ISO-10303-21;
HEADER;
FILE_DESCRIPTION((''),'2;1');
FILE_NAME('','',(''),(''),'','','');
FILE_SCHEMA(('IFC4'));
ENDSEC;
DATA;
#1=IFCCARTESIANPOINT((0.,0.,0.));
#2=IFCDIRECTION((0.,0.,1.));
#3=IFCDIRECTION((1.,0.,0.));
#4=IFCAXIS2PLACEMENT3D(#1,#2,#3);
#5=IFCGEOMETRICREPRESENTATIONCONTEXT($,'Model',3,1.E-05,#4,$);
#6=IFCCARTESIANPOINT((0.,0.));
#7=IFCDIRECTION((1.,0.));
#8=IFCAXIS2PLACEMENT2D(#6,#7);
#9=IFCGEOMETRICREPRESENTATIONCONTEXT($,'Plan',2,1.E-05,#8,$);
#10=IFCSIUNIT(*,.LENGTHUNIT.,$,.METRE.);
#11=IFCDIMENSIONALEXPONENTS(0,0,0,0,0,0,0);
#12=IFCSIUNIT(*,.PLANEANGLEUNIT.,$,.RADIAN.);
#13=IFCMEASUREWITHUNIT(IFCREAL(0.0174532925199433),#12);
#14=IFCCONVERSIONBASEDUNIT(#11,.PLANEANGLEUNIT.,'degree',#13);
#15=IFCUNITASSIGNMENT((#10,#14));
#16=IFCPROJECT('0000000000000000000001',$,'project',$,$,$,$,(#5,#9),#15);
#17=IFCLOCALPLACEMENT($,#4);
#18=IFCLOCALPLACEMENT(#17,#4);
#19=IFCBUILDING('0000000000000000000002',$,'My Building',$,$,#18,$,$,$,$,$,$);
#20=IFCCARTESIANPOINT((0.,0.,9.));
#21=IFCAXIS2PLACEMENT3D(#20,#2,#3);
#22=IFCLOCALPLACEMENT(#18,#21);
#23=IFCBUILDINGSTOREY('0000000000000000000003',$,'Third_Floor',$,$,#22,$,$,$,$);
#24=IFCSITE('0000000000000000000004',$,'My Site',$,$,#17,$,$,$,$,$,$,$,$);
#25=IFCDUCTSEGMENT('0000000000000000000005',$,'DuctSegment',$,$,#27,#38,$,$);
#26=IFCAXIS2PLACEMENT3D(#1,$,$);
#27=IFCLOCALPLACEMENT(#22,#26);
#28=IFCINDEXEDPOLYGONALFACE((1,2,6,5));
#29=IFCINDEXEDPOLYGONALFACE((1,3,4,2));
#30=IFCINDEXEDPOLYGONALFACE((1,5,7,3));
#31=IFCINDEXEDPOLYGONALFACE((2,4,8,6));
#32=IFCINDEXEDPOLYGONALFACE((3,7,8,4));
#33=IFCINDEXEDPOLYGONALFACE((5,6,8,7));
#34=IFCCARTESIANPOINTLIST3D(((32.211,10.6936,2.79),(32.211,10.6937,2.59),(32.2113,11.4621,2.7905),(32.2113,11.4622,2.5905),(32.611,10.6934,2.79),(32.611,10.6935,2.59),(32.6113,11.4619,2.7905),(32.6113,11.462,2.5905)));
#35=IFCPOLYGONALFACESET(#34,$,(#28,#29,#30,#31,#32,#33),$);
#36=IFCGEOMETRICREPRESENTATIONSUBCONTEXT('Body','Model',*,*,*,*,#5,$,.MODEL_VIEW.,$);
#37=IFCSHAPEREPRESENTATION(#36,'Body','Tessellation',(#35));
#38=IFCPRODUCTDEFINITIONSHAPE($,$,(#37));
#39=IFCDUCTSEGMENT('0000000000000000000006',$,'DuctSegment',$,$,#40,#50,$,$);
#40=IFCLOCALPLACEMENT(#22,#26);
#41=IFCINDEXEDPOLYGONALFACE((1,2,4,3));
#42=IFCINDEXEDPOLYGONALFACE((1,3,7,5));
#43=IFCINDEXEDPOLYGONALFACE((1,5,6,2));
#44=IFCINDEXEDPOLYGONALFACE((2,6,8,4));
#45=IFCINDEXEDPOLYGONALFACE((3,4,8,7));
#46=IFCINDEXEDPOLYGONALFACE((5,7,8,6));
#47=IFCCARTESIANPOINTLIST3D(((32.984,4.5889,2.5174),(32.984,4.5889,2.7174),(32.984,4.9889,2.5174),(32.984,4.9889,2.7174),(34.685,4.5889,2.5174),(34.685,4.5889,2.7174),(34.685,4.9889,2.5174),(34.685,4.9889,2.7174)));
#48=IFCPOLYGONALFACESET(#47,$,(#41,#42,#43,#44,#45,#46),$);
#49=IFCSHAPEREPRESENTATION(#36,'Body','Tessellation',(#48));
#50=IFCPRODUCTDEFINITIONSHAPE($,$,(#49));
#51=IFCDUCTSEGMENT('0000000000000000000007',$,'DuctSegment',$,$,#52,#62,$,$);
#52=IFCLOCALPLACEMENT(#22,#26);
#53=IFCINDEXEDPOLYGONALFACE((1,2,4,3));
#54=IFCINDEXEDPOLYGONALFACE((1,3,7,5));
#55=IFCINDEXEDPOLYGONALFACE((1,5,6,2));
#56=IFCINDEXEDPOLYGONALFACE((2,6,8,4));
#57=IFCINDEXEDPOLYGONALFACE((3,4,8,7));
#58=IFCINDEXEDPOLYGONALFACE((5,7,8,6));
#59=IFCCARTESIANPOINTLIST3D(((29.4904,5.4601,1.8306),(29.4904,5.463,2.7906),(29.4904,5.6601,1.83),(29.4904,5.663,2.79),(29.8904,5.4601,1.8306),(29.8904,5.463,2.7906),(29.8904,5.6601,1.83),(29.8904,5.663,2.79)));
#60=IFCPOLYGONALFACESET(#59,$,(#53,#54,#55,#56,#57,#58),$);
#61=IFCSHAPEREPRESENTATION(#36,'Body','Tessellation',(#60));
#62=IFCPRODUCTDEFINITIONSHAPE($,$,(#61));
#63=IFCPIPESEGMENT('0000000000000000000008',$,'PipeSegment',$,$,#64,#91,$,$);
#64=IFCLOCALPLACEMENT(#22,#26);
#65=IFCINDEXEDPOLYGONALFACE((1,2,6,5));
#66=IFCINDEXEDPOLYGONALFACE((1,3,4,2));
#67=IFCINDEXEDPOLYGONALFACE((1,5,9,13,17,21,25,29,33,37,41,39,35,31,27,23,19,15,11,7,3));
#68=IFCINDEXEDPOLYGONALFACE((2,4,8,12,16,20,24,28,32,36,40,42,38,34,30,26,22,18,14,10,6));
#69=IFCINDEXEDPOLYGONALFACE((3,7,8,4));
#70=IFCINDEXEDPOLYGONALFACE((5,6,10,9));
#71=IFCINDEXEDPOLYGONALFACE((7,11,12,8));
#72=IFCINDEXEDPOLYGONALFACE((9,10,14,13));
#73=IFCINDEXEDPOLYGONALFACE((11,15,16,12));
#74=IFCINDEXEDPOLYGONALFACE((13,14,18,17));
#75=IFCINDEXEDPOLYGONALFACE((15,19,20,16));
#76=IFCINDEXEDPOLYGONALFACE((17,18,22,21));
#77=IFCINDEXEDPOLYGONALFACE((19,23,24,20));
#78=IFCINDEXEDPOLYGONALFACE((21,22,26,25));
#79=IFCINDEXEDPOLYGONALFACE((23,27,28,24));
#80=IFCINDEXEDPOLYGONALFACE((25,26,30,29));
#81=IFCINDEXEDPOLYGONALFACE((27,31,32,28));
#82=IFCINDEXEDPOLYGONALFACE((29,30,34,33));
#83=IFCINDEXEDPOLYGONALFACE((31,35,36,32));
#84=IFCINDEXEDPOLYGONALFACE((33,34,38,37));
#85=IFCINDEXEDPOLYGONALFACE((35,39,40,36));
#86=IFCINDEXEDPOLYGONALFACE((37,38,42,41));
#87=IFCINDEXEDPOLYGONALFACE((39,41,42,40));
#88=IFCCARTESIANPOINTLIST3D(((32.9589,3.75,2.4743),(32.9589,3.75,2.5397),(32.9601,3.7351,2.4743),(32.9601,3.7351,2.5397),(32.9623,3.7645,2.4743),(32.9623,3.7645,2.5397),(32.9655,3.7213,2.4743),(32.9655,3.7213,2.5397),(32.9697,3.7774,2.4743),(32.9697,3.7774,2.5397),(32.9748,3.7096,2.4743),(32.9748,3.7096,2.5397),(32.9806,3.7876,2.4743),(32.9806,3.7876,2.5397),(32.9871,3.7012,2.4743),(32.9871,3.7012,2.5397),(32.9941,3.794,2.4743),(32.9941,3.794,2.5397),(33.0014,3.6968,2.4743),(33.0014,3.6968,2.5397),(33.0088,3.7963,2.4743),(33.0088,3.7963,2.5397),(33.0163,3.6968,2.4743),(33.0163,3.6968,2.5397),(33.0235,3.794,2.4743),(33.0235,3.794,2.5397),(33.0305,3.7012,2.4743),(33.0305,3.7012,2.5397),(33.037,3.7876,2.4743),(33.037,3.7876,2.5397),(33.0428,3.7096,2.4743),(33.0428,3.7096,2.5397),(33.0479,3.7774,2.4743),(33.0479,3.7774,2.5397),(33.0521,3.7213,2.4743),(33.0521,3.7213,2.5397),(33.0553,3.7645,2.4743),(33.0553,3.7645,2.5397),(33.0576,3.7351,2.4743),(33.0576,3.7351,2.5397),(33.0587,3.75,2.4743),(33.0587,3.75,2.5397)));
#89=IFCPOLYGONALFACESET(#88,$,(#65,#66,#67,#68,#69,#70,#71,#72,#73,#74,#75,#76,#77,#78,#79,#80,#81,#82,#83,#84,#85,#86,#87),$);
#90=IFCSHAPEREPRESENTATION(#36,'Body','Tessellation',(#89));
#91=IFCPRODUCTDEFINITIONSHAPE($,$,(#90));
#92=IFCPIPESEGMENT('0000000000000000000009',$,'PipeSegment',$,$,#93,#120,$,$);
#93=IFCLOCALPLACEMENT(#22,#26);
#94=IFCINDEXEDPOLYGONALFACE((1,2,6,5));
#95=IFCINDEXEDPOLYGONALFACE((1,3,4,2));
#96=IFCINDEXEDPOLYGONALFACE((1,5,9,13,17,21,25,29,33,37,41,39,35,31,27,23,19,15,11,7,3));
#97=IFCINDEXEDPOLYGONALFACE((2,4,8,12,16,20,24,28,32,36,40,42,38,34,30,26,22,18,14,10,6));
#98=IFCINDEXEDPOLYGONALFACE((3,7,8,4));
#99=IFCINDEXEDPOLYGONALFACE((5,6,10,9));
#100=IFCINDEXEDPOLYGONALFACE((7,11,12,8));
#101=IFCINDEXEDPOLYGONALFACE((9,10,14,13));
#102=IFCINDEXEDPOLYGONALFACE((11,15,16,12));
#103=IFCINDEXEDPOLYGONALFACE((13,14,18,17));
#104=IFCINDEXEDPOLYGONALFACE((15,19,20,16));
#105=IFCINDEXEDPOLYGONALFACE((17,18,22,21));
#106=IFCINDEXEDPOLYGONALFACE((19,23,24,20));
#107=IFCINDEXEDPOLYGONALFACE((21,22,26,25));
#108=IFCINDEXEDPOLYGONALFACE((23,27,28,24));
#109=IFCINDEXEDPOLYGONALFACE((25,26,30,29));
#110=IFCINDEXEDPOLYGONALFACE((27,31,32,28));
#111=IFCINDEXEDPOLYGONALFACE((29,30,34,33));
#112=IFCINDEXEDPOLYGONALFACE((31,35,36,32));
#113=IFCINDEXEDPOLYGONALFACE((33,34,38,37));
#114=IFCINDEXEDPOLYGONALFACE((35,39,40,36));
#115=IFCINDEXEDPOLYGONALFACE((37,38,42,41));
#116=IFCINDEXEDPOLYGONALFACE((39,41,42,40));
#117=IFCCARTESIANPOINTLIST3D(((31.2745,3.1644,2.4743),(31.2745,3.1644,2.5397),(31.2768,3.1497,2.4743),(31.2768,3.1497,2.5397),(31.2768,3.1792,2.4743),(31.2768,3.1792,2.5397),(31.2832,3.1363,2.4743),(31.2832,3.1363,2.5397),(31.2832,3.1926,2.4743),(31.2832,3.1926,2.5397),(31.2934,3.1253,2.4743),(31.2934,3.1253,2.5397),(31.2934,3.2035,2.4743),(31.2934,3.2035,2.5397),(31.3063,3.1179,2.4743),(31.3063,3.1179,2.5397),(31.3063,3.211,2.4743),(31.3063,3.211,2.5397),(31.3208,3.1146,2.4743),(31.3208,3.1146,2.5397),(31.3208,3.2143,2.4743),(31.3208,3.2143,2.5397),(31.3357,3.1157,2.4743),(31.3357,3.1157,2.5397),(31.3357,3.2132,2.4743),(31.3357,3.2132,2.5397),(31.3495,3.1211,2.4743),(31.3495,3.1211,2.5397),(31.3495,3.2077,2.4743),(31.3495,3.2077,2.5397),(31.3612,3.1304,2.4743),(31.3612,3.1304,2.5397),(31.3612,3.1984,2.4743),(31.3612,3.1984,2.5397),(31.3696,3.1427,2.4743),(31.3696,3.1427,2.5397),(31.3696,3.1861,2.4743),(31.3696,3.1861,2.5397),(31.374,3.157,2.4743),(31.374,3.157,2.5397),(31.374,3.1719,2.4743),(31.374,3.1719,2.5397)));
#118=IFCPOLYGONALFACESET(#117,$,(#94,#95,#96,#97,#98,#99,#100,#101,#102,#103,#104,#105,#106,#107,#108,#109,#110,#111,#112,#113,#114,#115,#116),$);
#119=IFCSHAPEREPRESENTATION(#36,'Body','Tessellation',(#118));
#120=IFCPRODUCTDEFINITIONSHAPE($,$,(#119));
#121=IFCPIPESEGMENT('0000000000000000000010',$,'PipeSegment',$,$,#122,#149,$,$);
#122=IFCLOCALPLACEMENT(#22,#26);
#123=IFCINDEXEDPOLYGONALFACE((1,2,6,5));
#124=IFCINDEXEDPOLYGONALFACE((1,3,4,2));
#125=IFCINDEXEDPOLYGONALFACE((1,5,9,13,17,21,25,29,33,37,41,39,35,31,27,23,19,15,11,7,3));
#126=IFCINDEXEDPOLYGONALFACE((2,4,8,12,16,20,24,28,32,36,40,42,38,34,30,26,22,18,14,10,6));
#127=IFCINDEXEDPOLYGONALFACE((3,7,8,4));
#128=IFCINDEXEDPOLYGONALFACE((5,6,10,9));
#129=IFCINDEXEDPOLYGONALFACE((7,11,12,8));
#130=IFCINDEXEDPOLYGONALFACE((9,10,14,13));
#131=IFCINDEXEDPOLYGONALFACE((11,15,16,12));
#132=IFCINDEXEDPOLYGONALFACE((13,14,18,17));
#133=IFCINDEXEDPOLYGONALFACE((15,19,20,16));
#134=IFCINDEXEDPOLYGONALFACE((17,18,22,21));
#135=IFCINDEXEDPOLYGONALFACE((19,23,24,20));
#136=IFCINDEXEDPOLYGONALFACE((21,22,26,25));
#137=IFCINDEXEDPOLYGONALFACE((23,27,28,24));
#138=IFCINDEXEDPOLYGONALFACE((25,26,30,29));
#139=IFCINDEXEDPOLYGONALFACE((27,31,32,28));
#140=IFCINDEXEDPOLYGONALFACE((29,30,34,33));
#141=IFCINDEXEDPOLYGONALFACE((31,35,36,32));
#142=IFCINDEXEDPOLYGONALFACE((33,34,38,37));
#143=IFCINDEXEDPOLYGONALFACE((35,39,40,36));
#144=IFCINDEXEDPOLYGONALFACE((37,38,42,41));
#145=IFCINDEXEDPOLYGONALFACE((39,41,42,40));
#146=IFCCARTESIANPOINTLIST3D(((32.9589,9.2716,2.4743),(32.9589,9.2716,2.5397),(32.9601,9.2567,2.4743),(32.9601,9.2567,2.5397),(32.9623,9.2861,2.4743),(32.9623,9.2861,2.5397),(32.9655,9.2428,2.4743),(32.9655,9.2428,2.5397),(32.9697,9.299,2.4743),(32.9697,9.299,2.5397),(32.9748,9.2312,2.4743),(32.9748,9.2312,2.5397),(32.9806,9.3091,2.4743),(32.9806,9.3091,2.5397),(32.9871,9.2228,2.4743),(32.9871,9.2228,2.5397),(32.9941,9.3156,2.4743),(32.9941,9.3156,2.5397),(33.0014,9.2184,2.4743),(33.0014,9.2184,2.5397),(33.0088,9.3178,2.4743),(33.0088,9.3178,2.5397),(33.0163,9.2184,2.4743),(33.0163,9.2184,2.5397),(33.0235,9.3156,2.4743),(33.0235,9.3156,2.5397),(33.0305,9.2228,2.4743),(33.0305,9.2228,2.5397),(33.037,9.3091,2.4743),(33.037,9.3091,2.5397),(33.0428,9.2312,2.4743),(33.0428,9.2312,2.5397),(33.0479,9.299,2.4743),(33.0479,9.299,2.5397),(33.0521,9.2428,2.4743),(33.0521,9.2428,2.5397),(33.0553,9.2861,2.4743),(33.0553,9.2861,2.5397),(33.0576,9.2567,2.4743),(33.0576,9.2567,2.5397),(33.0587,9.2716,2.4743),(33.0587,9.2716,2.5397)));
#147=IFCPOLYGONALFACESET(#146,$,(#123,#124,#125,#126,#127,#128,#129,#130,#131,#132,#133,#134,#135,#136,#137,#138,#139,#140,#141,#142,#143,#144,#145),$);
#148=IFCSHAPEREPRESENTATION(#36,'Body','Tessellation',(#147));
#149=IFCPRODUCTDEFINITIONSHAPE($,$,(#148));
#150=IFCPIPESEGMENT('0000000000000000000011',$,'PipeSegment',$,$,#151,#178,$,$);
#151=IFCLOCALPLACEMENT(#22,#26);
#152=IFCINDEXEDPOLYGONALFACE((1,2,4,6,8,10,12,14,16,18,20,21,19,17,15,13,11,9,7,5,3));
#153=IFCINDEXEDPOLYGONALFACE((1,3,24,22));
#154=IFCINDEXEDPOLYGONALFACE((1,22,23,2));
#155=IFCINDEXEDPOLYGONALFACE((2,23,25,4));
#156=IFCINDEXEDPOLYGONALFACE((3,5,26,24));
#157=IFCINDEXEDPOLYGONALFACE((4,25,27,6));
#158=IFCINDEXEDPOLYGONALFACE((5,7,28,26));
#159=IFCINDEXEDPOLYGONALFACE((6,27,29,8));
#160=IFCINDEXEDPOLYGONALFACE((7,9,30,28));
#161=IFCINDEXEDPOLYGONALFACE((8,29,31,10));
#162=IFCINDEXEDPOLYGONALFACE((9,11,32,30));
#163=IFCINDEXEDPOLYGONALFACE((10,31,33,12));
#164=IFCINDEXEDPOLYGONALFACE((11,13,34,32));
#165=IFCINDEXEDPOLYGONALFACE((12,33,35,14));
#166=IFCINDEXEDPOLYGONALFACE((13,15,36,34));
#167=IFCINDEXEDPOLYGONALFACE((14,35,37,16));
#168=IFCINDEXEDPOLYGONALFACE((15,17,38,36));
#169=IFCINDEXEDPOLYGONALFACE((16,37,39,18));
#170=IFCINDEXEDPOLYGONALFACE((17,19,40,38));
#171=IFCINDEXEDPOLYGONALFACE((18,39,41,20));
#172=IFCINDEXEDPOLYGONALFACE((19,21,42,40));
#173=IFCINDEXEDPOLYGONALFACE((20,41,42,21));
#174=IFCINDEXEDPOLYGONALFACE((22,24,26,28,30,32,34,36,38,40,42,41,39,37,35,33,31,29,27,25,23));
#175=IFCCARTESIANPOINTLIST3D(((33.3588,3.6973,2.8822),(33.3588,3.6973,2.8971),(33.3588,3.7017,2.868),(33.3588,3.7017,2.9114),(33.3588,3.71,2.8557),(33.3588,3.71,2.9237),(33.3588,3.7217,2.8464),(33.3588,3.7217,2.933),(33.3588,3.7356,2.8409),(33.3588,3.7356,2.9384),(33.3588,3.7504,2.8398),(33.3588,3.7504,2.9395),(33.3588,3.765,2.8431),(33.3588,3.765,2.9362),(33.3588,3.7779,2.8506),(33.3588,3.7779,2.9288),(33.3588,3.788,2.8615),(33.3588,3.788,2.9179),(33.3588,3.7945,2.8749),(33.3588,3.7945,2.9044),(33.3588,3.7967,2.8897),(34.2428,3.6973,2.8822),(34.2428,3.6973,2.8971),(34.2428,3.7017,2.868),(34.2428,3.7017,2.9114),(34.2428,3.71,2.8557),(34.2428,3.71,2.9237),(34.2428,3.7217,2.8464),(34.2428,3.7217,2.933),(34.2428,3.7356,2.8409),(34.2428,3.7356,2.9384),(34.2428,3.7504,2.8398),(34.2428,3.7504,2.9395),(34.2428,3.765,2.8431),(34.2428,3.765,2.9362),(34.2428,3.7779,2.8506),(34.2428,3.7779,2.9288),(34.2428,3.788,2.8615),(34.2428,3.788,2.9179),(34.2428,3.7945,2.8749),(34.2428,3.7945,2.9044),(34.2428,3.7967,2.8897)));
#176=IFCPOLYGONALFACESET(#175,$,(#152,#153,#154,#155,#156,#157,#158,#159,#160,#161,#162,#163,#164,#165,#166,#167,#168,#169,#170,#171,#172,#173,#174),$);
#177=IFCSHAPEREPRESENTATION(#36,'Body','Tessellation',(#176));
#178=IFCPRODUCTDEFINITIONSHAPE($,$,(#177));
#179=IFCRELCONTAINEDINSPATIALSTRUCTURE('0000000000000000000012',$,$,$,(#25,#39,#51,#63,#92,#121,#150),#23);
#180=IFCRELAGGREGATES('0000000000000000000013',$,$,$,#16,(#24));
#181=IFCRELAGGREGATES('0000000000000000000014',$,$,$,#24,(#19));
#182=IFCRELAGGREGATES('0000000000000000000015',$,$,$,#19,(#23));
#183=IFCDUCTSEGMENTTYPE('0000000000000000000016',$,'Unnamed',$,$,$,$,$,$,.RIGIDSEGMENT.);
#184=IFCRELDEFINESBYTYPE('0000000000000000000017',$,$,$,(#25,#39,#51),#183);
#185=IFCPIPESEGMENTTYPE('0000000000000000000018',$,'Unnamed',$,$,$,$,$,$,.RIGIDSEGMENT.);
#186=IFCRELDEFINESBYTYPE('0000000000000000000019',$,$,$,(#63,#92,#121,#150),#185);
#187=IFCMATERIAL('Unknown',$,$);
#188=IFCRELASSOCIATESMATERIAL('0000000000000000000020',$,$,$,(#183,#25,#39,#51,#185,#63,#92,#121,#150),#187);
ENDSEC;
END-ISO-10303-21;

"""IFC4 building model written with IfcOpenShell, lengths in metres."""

from ifc_helpers import new_model, entity, si_unit, converted_unit, frame, origin_with_axes, origin_2d_with_axis, place, context, subcontext, project, spatial, rectangle, circle, extrude, material, material_profile, profile_set, profile_usage, type_object, element, save


model = new_model("IFC4")

# Units and contexts
model_context = context("Model", 3, precision=1e-05, world=origin_with_axes())
plan_context = context("Plan", 2, precision=1e-05, world=origin_2d_with_axis())
body_context_1 = subcontext(model_context, "Body", "Model", "MODEL_VIEW")
ifc_project = project(units=[si_unit("LENGTHUNIT", "METRE"), converted_unit("PLANEANGLEUNIT", "degree", entity("IfcReal", 0.0174532925199433), si_unit("PLANEANGLEUNIT", "RADIAN"), dimensions=[0, 0, 0, 0, 0, 0, 0])], contexts=[model_context, plan_context])

# Site, building, storey
site_placement = place(None, origin_with_axes())
site = spatial("IfcSite", under=ifc_project, at=site_placement, Name="My Site")
building_placement = place(site_placement, origin_with_axes())
building = spatial("IfcBuilding", under=site, at=building_placement, Name="My Building")
storey_placement = place(building_placement, frame((0.0, 0.0, 9.0), z_axis=(0.0, 0.0, 1.0), x_axis=(1.0, 0.0, 0.0)))
storey = spatial("IfcBuildingStorey", under=building, at=storey_placement, Name="Third_Floor")

# Shared definitions
ifc_material = material(Name="Unknown")

# Duct segments
ifc_material_profile_1 = material_profile(ifc_material, rectangle(XDim=0.4, YDim=0.2))
ifc_profile_set_1 = profile_set([ifc_material_profile_1])
duct_segment_type = type_object("IfcDuctSegmentType", Name="Unnamed", PredefinedType="RIGIDSEGMENT", material=ifc_profile_set_1)
ifc_profile_usage_1 = profile_usage(ifc_profile_set_1, cardinal=5)
duct_segment_1_placement = place(storey_placement, frame((32.4113, 11.462, 2.6905), z_axis=(-0.000397, -1.0, -0.000603), x_axis=(1.0, -0.000397, 0.0)))
element("IfcDuctSegment", 1, at=duct_segment_1_placement, inside=storey, type_object=duct_segment_type, material=ifc_profile_usage_1, Name="DuctSegment", context=body_context_1, shape_type="SweptSolid", body=[
    extrude(rectangle(XDim=0.4, YDim=0.2), origin_with_axes(), (0.0, 0.0, 1.0), 0.7685),
])
ifc_profile_usage_2 = profile_usage(ifc_profile_set_1, cardinal=5)
duct_segment_2_placement = place(storey_placement, frame((34.685, 4.7889, 2.6174), z_axis=(-1.0, 0.000001, 0.000001), x_axis=(-0.000001, -1.0, 0.0)))
element("IfcDuctSegment", 2, at=duct_segment_2_placement, inside=storey, type_object=duct_segment_type, material=ifc_profile_usage_2, Name="DuctSegment", context=body_context_1, shape_type="SweptSolid", body=[
    extrude(rectangle(XDim=0.4, YDim=0.2), origin_with_axes(), (0.0, 0.0, 1.0), 1.701),
])
ifc_profile_usage_3 = profile_usage(ifc_profile_set_1, cardinal=5)
duct_segment_3_placement = place(storey_placement, frame((29.6904, 5.563, 2.7903), z_axis=(0.0, -0.00299, -0.999996), x_axis=(1.0, 0.0, 0.0)))
element("IfcDuctSegment", 3, at=duct_segment_3_placement, inside=storey, type_object=duct_segment_type, material=ifc_profile_usage_3, Name="DuctSegment", context=body_context_1, shape_type="SweptSolid", body=[
    extrude(rectangle(XDim=0.4, YDim=0.2), origin_with_axes(), (0.0, 0.0, 1.0), 0.96),
])

# Pipe segments
ifc_material_profile_2 = material_profile(ifc_material, circle(Radius=0.05))
ifc_profile_set_2 = profile_set([ifc_material_profile_2])
ifc_profile_usage_4 = profile_usage(ifc_profile_set_2, cardinal=5)
pipe_segment_type = type_object("IfcPipeSegmentType", Name="Unnamed", PredefinedType="RIGIDSEGMENT", material=ifc_profile_set_2)
pipe_segment_1_placement = place(storey_placement, frame((33.0088, 3.7463, 2.4743), z_axis=(0.0, 0.0, 1.0), x_axis=(-0.000001, 1.0, 0.0)))
element("IfcPipeSegment", 4, at=pipe_segment_1_placement, inside=storey, type_object=pipe_segment_type, material=ifc_profile_usage_4, Name="PipeSegment", context=body_context_1, shape_type="SweptSolid", body=[
    extrude(circle(Radius=0.05), origin_with_axes(), (0.0, 0.0, 1.0), 0.0654),
])
ifc_profile_usage_5 = profile_usage(ifc_profile_set_2, cardinal=5)
pipe_segment_2_placement = place(storey_placement, frame((31.3245, 3.1644, 2.4743), z_axis=(0.0, 0.0, 1.0), x_axis=(-1.0, -0.000001, 0.0)))
element("IfcPipeSegment", 5, at=pipe_segment_2_placement, inside=storey, type_object=pipe_segment_type, material=ifc_profile_usage_5, Name="PipeSegment", context=body_context_1, shape_type="SweptSolid", body=[
    extrude(circle(Radius=0.05), origin_with_axes(), (0.0, 0.0, 1.0), 0.0654),
])
ifc_profile_usage_6 = profile_usage(ifc_profile_set_2, cardinal=5)
pipe_segment_3_placement = place(storey_placement, frame((33.0088, 9.2678, 2.4743), z_axis=(0.0, 0.0, 1.0), x_axis=(-0.000001, 1.0, 0.0)))
element("IfcPipeSegment", 6, at=pipe_segment_3_placement, inside=storey, type_object=pipe_segment_type, material=ifc_profile_usage_6, Name="PipeSegment", context=body_context_1, shape_type="SweptSolid", body=[
    extrude(circle(Radius=0.05), origin_with_axes(), (0.0, 0.0, 1.0), 0.0654),
])
ifc_profile_usage_7 = profile_usage(ifc_profile_set_2, cardinal=5)
pipe_segment_4_placement = place(storey_placement, frame((33.3588, 3.7467, 2.8897), z_axis=(1.0, 0.0, 0.0), x_axis=(0.0, 1.0, 0.0)))
element("IfcPipeSegment", 7, at=pipe_segment_4_placement, inside=storey, type_object=pipe_segment_type, material=ifc_profile_usage_7, Name="PipeSegment", context=body_context_1, shape_type="SweptSolid", body=[
    extrude(circle(Radius=0.05), origin_with_axes(), (0.0, 0.0, 1.0), 0.884),
])

save(model, "model.ifc")
